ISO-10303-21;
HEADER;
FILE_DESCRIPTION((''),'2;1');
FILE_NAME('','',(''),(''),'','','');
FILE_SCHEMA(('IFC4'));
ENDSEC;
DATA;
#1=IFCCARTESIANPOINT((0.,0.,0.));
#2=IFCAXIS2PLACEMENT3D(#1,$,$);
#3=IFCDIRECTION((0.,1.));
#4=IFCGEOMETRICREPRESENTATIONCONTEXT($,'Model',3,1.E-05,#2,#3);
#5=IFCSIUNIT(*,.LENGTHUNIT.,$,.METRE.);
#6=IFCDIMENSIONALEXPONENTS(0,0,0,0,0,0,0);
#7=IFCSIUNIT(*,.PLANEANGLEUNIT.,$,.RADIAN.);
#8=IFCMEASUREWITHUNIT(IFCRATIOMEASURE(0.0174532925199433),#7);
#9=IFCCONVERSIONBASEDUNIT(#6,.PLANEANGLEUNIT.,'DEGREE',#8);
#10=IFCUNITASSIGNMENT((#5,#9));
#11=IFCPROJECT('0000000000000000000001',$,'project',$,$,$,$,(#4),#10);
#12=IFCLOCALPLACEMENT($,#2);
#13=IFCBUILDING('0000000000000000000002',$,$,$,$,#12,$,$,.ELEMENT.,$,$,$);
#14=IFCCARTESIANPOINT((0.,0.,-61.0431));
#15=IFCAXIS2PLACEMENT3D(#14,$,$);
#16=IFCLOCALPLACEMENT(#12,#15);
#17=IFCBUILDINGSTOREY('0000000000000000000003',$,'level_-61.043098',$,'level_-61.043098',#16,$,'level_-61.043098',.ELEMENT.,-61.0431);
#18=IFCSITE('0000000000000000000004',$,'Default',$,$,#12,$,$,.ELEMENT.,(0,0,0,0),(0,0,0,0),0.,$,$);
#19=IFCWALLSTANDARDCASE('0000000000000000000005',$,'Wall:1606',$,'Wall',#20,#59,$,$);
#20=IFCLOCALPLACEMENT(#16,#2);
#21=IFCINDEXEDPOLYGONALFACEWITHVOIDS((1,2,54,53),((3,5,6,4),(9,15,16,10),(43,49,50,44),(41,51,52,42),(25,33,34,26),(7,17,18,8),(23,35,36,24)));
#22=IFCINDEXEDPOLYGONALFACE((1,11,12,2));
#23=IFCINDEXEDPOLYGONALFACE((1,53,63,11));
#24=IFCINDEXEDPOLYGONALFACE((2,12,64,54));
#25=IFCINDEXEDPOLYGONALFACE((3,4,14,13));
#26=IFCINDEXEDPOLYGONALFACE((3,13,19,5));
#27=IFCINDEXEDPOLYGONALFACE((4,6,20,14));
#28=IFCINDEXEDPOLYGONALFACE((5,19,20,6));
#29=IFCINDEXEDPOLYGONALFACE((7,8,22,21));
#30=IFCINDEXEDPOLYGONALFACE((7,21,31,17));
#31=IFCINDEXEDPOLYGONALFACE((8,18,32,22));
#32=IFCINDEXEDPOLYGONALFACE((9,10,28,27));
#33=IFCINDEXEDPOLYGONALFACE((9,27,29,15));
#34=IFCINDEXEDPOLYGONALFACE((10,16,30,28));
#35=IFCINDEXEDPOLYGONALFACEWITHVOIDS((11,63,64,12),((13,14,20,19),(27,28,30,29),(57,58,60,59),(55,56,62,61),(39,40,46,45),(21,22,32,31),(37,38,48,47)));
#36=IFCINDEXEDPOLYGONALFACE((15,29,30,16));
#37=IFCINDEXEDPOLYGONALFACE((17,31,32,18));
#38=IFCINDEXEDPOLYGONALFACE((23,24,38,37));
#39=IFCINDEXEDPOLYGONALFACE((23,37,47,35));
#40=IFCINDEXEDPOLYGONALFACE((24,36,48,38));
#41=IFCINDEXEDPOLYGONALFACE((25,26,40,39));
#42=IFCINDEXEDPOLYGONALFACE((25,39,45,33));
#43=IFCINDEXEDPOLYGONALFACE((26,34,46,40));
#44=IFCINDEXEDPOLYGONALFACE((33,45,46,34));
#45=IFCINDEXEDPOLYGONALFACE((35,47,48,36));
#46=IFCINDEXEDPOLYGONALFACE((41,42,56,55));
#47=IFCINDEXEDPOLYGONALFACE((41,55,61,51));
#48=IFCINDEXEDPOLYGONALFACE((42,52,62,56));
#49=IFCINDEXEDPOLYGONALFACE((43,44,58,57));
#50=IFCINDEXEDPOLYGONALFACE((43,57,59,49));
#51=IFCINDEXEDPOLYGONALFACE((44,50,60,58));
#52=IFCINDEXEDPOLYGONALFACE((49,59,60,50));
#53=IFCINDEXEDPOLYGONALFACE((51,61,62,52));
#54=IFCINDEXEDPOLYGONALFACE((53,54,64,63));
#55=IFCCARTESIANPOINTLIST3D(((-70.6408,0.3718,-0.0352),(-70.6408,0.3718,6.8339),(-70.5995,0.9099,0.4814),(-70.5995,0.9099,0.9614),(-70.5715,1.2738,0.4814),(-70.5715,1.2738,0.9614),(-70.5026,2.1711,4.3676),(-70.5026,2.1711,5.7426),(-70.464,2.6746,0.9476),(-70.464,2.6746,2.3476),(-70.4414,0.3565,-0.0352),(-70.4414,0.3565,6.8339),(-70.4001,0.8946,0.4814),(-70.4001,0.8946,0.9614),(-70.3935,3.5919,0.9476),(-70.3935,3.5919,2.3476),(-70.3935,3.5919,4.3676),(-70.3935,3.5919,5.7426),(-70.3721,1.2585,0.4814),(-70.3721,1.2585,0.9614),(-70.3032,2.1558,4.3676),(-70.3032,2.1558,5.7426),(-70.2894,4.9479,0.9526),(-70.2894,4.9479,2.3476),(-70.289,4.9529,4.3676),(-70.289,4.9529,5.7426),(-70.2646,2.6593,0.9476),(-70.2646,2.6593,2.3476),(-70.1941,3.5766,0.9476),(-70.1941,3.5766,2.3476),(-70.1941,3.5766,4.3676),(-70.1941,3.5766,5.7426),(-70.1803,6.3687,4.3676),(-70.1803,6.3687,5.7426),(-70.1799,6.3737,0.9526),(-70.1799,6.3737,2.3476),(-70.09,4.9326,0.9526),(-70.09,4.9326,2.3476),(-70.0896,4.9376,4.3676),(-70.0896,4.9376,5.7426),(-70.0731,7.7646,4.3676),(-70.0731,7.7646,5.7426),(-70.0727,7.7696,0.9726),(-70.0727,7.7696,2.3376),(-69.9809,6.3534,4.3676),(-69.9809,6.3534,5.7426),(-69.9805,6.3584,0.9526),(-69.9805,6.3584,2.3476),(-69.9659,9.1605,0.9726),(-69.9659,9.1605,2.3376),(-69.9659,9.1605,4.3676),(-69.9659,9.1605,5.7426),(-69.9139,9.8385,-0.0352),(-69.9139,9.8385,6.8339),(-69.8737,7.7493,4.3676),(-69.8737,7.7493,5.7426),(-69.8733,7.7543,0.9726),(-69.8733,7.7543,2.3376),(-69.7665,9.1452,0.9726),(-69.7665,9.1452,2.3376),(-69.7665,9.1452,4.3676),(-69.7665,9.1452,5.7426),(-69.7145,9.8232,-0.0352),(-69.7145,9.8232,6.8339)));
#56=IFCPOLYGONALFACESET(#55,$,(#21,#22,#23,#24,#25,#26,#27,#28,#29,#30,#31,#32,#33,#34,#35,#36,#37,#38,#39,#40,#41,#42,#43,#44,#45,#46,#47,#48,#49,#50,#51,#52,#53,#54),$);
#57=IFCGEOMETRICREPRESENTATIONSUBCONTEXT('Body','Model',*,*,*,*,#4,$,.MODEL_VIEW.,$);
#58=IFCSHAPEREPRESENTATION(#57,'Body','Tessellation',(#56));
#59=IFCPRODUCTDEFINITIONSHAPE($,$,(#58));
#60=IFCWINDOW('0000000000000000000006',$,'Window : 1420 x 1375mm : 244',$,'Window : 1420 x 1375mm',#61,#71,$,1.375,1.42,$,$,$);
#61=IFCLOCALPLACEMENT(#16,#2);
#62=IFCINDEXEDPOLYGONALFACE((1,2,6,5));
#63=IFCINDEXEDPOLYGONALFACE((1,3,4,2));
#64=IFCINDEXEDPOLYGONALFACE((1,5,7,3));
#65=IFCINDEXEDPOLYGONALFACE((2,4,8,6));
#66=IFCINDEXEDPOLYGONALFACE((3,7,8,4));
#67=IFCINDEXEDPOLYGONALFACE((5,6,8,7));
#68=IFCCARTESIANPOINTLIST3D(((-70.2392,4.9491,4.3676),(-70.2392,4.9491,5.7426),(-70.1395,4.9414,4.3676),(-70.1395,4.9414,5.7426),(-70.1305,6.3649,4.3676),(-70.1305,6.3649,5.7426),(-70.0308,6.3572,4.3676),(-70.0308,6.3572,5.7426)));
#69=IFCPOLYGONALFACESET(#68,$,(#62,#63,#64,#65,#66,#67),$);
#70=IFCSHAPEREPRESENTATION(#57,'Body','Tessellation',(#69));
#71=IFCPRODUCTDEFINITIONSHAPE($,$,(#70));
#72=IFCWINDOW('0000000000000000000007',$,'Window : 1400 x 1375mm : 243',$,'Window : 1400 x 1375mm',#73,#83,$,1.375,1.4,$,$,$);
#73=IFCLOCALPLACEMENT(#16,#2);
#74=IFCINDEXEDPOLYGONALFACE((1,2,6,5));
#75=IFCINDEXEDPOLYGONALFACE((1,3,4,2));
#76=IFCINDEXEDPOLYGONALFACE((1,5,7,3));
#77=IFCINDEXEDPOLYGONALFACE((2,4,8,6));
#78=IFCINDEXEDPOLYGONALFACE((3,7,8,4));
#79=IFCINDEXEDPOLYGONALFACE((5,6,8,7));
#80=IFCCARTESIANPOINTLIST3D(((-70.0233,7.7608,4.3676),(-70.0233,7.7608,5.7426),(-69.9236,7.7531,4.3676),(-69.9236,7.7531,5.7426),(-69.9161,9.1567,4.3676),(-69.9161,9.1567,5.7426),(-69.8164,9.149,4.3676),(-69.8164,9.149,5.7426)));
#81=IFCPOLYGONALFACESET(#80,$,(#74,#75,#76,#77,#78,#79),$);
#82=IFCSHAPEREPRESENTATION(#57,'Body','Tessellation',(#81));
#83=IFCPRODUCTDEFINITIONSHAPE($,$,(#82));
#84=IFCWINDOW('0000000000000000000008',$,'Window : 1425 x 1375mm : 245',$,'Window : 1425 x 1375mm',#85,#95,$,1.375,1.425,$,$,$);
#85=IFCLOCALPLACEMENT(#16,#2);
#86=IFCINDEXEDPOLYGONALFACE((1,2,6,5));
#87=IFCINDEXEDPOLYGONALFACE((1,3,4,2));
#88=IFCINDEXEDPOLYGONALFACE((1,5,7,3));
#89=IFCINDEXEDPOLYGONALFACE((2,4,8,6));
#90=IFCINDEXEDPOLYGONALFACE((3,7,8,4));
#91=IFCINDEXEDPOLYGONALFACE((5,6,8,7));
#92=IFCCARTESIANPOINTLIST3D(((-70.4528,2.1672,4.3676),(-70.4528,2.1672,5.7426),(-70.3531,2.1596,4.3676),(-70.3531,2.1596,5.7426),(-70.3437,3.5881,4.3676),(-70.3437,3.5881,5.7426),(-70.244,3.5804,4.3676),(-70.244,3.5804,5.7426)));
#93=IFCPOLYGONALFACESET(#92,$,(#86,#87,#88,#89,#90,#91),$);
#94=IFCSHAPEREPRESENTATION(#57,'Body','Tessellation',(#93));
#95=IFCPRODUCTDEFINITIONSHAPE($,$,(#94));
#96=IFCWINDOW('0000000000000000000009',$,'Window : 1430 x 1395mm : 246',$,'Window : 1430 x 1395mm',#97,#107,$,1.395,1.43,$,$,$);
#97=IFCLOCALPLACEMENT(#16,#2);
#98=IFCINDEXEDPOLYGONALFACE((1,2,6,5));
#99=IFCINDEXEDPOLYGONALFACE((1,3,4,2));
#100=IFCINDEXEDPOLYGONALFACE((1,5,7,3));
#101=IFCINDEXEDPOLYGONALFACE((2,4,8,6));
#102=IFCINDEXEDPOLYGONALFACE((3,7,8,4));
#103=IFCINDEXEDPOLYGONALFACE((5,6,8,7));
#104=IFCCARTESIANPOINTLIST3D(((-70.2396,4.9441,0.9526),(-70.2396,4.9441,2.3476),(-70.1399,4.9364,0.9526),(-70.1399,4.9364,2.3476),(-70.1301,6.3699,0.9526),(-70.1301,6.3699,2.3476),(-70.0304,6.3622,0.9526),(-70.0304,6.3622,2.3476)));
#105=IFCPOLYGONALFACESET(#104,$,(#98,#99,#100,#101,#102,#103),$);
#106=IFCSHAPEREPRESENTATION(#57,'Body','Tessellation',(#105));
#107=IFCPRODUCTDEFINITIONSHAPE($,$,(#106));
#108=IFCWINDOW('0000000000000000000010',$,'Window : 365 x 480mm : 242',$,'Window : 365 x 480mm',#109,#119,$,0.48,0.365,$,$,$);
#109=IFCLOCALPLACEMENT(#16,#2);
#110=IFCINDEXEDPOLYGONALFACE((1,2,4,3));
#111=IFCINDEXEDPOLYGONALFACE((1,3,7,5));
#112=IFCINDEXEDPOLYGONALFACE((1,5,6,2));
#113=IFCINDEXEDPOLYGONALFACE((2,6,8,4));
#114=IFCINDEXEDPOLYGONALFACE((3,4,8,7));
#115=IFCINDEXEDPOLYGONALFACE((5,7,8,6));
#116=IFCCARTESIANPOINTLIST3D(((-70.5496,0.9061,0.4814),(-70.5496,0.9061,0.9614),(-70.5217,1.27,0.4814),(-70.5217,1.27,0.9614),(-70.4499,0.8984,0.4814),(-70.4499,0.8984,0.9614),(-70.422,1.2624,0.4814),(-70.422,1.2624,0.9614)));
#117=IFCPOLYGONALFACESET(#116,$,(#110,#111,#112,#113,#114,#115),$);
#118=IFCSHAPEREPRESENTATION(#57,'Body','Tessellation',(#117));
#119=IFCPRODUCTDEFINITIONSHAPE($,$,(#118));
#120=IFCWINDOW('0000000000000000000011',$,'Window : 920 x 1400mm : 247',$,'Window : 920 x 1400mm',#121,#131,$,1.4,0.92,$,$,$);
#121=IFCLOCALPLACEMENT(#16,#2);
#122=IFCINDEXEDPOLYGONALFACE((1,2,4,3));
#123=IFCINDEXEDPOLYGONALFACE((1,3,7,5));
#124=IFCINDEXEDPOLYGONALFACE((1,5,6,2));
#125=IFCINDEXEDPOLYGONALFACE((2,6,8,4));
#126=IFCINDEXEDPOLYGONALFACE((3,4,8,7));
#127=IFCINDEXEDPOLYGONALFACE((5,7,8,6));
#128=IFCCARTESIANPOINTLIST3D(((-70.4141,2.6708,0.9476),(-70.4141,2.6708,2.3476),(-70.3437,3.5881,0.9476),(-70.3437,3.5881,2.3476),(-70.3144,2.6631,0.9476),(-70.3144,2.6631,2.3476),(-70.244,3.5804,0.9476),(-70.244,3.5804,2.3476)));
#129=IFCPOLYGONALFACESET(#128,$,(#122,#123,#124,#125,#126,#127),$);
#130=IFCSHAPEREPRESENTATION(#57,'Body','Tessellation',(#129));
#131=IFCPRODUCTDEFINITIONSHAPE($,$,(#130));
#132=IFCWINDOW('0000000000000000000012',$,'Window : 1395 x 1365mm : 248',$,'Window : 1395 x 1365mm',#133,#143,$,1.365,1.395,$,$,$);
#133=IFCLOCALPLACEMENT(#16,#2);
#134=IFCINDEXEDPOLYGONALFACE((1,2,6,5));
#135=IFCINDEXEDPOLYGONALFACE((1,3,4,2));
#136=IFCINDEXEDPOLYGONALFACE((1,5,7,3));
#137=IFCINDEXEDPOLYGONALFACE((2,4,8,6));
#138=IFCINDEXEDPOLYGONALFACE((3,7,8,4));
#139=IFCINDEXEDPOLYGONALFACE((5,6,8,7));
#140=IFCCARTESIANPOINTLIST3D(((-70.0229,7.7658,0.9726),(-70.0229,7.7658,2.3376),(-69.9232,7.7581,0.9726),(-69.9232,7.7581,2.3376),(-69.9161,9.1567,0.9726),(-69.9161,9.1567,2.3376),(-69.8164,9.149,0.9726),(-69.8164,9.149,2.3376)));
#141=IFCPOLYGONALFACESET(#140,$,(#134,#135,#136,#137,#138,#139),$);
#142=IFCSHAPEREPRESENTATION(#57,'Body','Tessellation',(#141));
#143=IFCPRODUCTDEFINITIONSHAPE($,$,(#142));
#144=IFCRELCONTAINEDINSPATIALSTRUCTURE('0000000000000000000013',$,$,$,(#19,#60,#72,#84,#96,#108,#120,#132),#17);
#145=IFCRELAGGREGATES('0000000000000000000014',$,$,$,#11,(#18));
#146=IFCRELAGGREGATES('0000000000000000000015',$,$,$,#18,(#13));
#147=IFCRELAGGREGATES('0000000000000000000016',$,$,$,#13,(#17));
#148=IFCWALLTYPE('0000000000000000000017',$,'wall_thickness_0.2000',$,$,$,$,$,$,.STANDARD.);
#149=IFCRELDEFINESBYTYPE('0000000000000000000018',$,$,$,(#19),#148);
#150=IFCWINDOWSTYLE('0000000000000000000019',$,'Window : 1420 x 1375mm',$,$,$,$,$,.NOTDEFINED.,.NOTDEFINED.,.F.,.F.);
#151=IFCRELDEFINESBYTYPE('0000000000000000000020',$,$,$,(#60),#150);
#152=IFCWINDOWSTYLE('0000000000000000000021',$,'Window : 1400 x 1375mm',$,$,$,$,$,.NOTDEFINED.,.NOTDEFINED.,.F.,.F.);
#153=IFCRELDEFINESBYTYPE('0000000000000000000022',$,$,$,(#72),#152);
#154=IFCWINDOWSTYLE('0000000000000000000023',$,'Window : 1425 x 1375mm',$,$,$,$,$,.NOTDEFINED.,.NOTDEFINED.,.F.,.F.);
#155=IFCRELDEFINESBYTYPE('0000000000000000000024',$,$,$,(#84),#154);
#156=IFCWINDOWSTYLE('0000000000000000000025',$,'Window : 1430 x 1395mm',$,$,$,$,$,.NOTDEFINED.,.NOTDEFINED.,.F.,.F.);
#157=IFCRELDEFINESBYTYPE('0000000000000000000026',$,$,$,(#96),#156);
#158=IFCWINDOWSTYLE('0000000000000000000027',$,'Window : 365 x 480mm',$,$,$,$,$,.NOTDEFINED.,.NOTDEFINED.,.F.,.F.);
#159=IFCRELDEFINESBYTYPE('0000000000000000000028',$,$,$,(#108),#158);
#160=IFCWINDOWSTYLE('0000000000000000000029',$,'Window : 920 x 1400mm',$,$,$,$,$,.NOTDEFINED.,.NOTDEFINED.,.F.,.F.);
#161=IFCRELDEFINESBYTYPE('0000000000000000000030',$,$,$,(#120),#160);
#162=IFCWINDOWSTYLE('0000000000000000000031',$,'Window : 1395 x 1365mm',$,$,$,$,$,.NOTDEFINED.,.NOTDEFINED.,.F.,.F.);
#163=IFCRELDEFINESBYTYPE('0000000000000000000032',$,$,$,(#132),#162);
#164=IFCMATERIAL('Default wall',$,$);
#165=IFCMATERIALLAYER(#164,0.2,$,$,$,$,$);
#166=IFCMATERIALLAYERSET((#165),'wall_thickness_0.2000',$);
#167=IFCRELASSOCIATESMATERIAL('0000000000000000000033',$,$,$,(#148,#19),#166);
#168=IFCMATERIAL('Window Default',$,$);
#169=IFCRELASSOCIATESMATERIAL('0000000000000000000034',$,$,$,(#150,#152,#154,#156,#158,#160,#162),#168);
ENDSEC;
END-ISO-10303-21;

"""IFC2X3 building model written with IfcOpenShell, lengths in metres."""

from ifc_helpers import new_model, entity, si_unit, converted_unit, direction, frame, frame_2d, origin, origin_2d_with_axis, place, context, subcontext, project, spatial, polyline, rectangle, outline, extrude, source, transform, mapped, material, layer, layer_set, layer_usage, type_object, type_shapes, element, fill, save


model = new_model("IFC2X3")

# Units and contexts
model_context = context("Model", 3, precision=1e-05, world=origin(), true_north=direction((0.0, 1.0)))
body_context = subcontext(model_context, "Body", "Model", "MODEL_VIEW")
ifc_project = project(units=[si_unit("LENGTHUNIT", "METRE"), converted_unit("PLANEANGLEUNIT", "DEGREE", entity("IfcRatioMeasure", 0.0174532925199433), si_unit("PLANEANGLEUNIT", "RADIAN"), dimensions=[0, 0, 0, 0, 0, 0, 0])], contexts=[model_context])

# Site, building, storey
placement_1 = place(None, origin())
site = spatial("IfcSite", under=ifc_project, at=placement_1, Name="Default", CompositionType="ELEMENT", RefLatitude=(0, 0, 0, 0), RefLongitude=(0, 0, 0, 0), RefElevation=0.0)
building = spatial("IfcBuilding", under=site, at=placement_1, CompositionType="ELEMENT")
storey_placement = place(placement_1, frame((0.0, 0.0, -61.0431)))
storey = spatial("IfcBuildingStorey", under=building, at=storey_placement, Name="level_-61.043098", ObjectType="level_-61.043098", LongName="level_-61.043098", CompositionType="ELEMENT", Elevation=-61.0431)

# Shared definitions
ifc_material_1 = material(Name="Default wall")
ifc_layer = layer(ifc_material_1, 0.2)
ifc_layer_set = layer_set([ifc_layer], Name="wall_thickness_0.2000")
ifc_layer_usage = layer_usage(ifc_layer_set, "AXIS2", "POSITIVE", -0.1)
wall_type = type_object("IfcWallType", Name="wall_thickness_0.2000", PredefinedType="STANDARD", material=ifc_layer_set)

# Wall, openings, windows
placement_2 = place(placement_1, frame((0.0, 0.0, -61.0783)))
wall_1_placement = place(placement_2, frame((-69.8142, 9.8308, 0.0), z_axis=(0.0, 0.0, 1.0), x_axis=(-0.076563, -0.997065, 0.0)))
wall_1 = element("IfcWallStandardCase", 1, at=wall_1_placement, inside=storey, type_object=wall_type, material=ifc_layer_usage, Name="Wall:1606", ObjectType="Wall", context=body_context, shape_type="SweptSolid", body=[
    extrude(outline(polyline([(9.4946, -0.1), (9.4946, 0.1), (0.0, 0.1), (0.0, -0.1), (9.4946, -0.1)])), origin(), (0.0, 0.0, 1.0), 6.8691),
])
opening_1_placement = place(wall_1_placement, frame((8.5899, -0.1, 0.5166)))
opening_1 = element("IfcOpeningElement", 2, at=opening_1_placement, cuts=wall_1, ObjectType="Opening", context=body_context, shape_type="SweptSolid", body=[
    extrude(rectangle(XDim=0.365, YDim=0.48, at=frame_2d((0.24, 0.1825), x_axis=(0.0, 1.0))), frame((0.0, 0.0, 0.0), z_axis=(0.0, 1.0, 0.0), x_axis=(0.0, 0.0, 1.0)), (0.0, 0.0, 1.0), 0.2),
])
opening_2_placement = place(wall_1_placement, frame((0.68, -0.1, 4.4028)))
opening_2 = element("IfcOpeningElement", 3, at=opening_2_placement, cuts=wall_1, ObjectType="Opening", context=body_context, shape_type="SweptSolid", body=[
    extrude(rectangle(XDim=1.4, YDim=1.375, at=frame_2d((0.6875, 0.7), x_axis=(0.0, 1.0))), frame((0.0, 0.0, 0.0), z_axis=(0.0, 1.0, 0.0), x_axis=(0.0, 0.0, 1.0)), (0.0, 0.0, 1.0), 0.2),
])
opening_3_placement = place(wall_1_placement, frame((3.48, -0.1, 4.4028)))
opening_3 = element("IfcOpeningElement", 4, at=opening_3_placement, cuts=wall_1, ObjectType="Opening", context=body_context, shape_type="SweptSolid", body=[
    extrude(rectangle(XDim=1.42, YDim=1.375, at=frame_2d((0.6875, 0.71), x_axis=(0.0, 1.0))), frame((0.0, 0.0, 0.0), z_axis=(0.0, 1.0, 0.0), x_axis=(0.0, 0.0, 1.0)), (0.0, 0.0, 1.0), 0.2),
])
opening_4_placement = place(wall_1_placement, frame((6.265, -0.1, 4.4028)))
opening_4 = element("IfcOpeningElement", 5, at=opening_4_placement, cuts=wall_1, ObjectType="Opening", context=body_context, shape_type="SweptSolid", body=[
    extrude(rectangle(XDim=1.425, YDim=1.375, at=frame_2d((0.6875, 0.7125), x_axis=(0.0, 1.0))), frame((0.0, 0.0, 0.0), z_axis=(0.0, 1.0, 0.0), x_axis=(0.0, 0.0, 1.0)), (0.0, 0.0, 1.0), 0.2),
])
opening_5_placement = place(wall_1_placement, frame((3.475, -0.1, 0.9878)))
opening_5 = element("IfcOpeningElement", 6, at=opening_5_placement, cuts=wall_1, ObjectType="Opening", context=body_context, shape_type="SweptSolid", body=[
    extrude(rectangle(XDim=1.43, YDim=1.395, at=frame_2d((0.6975, 0.715), x_axis=(0.0, 1.0))), frame((0.0, 0.0, 0.0), z_axis=(0.0, 1.0, 0.0), x_axis=(0.0, 0.0, 1.0)), (0.0, 0.0, 1.0), 0.2),
])
opening_6_placement = place(wall_1_placement, frame((6.265, -0.1, 0.9828)))
opening_6 = element("IfcOpeningElement", 7, at=opening_6_placement, cuts=wall_1, ObjectType="Opening", context=body_context, shape_type="SweptSolid", body=[
    extrude(rectangle(XDim=0.92, YDim=1.4, at=frame_2d((0.7, 0.46), x_axis=(0.0, 1.0))), frame((0.0, 0.0, 0.0), z_axis=(0.0, 1.0, 0.0), x_axis=(0.0, 0.0, 1.0)), (0.0, 0.0, 1.0), 0.2),
])
opening_7_placement = place(wall_1_placement, frame((0.68, -0.1, 1.0078)))
opening_7 = element("IfcOpeningElement", 8, at=opening_7_placement, cuts=wall_1, ObjectType="Opening", context=body_context, shape_type="SweptSolid", body=[
    extrude(rectangle(XDim=1.395, YDim=1.365, at=frame_2d((0.6825, 0.6975), x_axis=(0.0, 1.0))), frame((0.0, 0.0, 0.0), z_axis=(0.0, 1.0, 0.0), x_axis=(0.0, 0.0, 1.0)), (0.0, 0.0, 1.0), 0.2),
])
ifc_material_2 = material(Name="Window Default")
window_style_1 = type_object("IfcWindowStyle", Name="Window : 1420 x 1375mm", ConstructionType="NOTDEFINED", OperationType="NOTDEFINED", ParameterTakesPrecedence=False, Sizeable=False, material=ifc_material_2)
shared_shape_1 = source(origin(), body_context, "Body", "SweptSolid", [
    extrude(rectangle(XDim=0.1, YDim=1.42, at=origin_2d_with_axis()), frame((0.71, 0.1, 0.0), z_axis=(0.0, 0.0, 1.0), x_axis=(0.0, 1.0, 0.0)), (0.0, 0.0, 1.0), 1.375),
])
type_shapes(window_style_1, [shared_shape_1])
window_1_placement = place(opening_3_placement, origin())
window_1 = element("IfcWindow", 9, at=window_1_placement, inside=storey, type_object=window_style_1, Name="Window : 1420 x 1375mm : 244", ObjectType="Window : 1420 x 1375mm", OverallHeight=1.375, OverallWidth=1.42, context=body_context, shape_type="MappedRepresentation", body=[
    mapped(shared_shape_1, transform((0.0, 0.0, 0.0), scale=1.0)),
])
fill(opening_3, window_1)
window_style_2 = type_object("IfcWindowStyle", Name="Window : 1400 x 1375mm", ConstructionType="NOTDEFINED", OperationType="NOTDEFINED", ParameterTakesPrecedence=False, Sizeable=False, material=ifc_material_2)
shared_shape_2 = source(origin(), body_context, "Body", "SweptSolid", [
    extrude(rectangle(XDim=0.1, YDim=1.4, at=origin_2d_with_axis()), frame((0.7, 0.1, 0.0), z_axis=(0.0, 0.0, 1.0), x_axis=(0.0, 1.0, 0.0)), (0.0, 0.0, 1.0), 1.375),
])
type_shapes(window_style_2, [shared_shape_2])
window_2_placement = place(opening_2_placement, origin())
window_2 = element("IfcWindow", 10, at=window_2_placement, inside=storey, type_object=window_style_2, Name="Window : 1400 x 1375mm : 243", ObjectType="Window : 1400 x 1375mm", OverallHeight=1.375, OverallWidth=1.4, context=body_context, shape_type="MappedRepresentation", body=[
    mapped(shared_shape_2, transform((0.0, 0.0, 0.0), scale=1.0)),
])
fill(opening_2, window_2)
window_style_3 = type_object("IfcWindowStyle", Name="Window : 1425 x 1375mm", ConstructionType="NOTDEFINED", OperationType="NOTDEFINED", ParameterTakesPrecedence=False, Sizeable=False, material=ifc_material_2)
shared_shape_3 = source(origin(), body_context, "Body", "SweptSolid", [
    extrude(rectangle(XDim=0.1, YDim=1.425, at=origin_2d_with_axis()), frame((0.7125, 0.1, 0.0), z_axis=(0.0, 0.0, 1.0), x_axis=(0.0, 1.0, 0.0)), (0.0, 0.0, 1.0), 1.375),
])
type_shapes(window_style_3, [shared_shape_3])
window_3_placement = place(opening_4_placement, origin())
window_3 = element("IfcWindow", 11, at=window_3_placement, inside=storey, type_object=window_style_3, Name="Window : 1425 x 1375mm : 245", ObjectType="Window : 1425 x 1375mm", OverallHeight=1.375, OverallWidth=1.425, context=body_context, shape_type="MappedRepresentation", body=[
    mapped(shared_shape_3, transform((0.0, 0.0, 0.0), scale=1.0)),
])
fill(opening_4, window_3)
window_style_4 = type_object("IfcWindowStyle", Name="Window : 1430 x 1395mm", ConstructionType="NOTDEFINED", OperationType="NOTDEFINED", ParameterTakesPrecedence=False, Sizeable=False, material=ifc_material_2)
shared_shape_4 = source(origin(), body_context, "Body", "SweptSolid", [
    extrude(rectangle(XDim=0.1, YDim=1.43, at=origin_2d_with_axis()), frame((0.715, 0.1, 0.0), z_axis=(0.0, 0.0, 1.0), x_axis=(0.0, 1.0, 0.0)), (0.0, 0.0, 1.0), 1.395),
])
type_shapes(window_style_4, [shared_shape_4])
window_4_placement = place(opening_5_placement, origin())
window_4 = element("IfcWindow", 12, at=window_4_placement, inside=storey, type_object=window_style_4, Name="Window : 1430 x 1395mm : 246", ObjectType="Window : 1430 x 1395mm", OverallHeight=1.395, OverallWidth=1.43, context=body_context, shape_type="MappedRepresentation", body=[
    mapped(shared_shape_4, transform((0.0, 0.0, 0.0), scale=1.0)),
])
fill(opening_5, window_4)
window_style_5 = type_object("IfcWindowStyle", Name="Window : 365 x 480mm", ConstructionType="NOTDEFINED", OperationType="NOTDEFINED", ParameterTakesPrecedence=False, Sizeable=False, material=ifc_material_2)
shared_shape_5 = source(origin(), body_context, "Body", "SweptSolid", [
    extrude(rectangle(XDim=0.1, YDim=0.365, at=origin_2d_with_axis()), frame((0.1825, 0.1, 0.0), z_axis=(0.0, 0.0, 1.0), x_axis=(0.0, 1.0, 0.0)), (0.0, 0.0, 1.0), 0.48),
])
type_shapes(window_style_5, [shared_shape_5])
window_5_placement = place(opening_1_placement, origin())
window_5 = element("IfcWindow", 13, at=window_5_placement, inside=storey, type_object=window_style_5, Name="Window : 365 x 480mm : 242", ObjectType="Window : 365 x 480mm", OverallHeight=0.48, OverallWidth=0.365, context=body_context, shape_type="MappedRepresentation", body=[
    mapped(shared_shape_5, transform((0.0, 0.0, 0.0), scale=1.0)),
])
fill(opening_1, window_5)
window_style_6 = type_object("IfcWindowStyle", Name="Window : 920 x 1400mm", ConstructionType="NOTDEFINED", OperationType="NOTDEFINED", ParameterTakesPrecedence=False, Sizeable=False, material=ifc_material_2)
shared_shape_6 = source(origin(), body_context, "Body", "SweptSolid", [
    extrude(rectangle(XDim=0.1, YDim=0.92, at=origin_2d_with_axis()), frame((0.46, 0.1, 0.0), z_axis=(0.0, 0.0, 1.0), x_axis=(0.0, 1.0, 0.0)), (0.0, 0.0, 1.0), 1.4),
])
type_shapes(window_style_6, [shared_shape_6])
window_6_placement = place(opening_6_placement, origin())
window_6 = element("IfcWindow", 14, at=window_6_placement, inside=storey, type_object=window_style_6, Name="Window : 920 x 1400mm : 247", ObjectType="Window : 920 x 1400mm", OverallHeight=1.4, OverallWidth=0.92, context=body_context, shape_type="MappedRepresentation", body=[
    mapped(shared_shape_6, transform((0.0, 0.0, 0.0), scale=1.0)),
])
fill(opening_6, window_6)
window_style_7 = type_object("IfcWindowStyle", Name="Window : 1395 x 1365mm", ConstructionType="NOTDEFINED", OperationType="NOTDEFINED", ParameterTakesPrecedence=False, Sizeable=False, material=ifc_material_2)
shared_shape_7 = source(origin(), body_context, "Body", "SweptSolid", [
    extrude(rectangle(XDim=0.1, YDim=1.395, at=origin_2d_with_axis()), frame((0.6975, 0.1, 0.0), z_axis=(0.0, 0.0, 1.0), x_axis=(0.0, 1.0, 0.0)), (0.0, 0.0, 1.0), 1.365),
])
type_shapes(window_style_7, [shared_shape_7])
window_7_placement = place(opening_7_placement, origin())
window_7 = element("IfcWindow", 15, at=window_7_placement, inside=storey, type_object=window_style_7, Name="Window : 1395 x 1365mm : 248", ObjectType="Window : 1395 x 1365mm", OverallHeight=1.365, OverallWidth=1.395, context=body_context, shape_type="MappedRepresentation", body=[
    mapped(shared_shape_7, transform((0.0, 0.0, 0.0), scale=1.0)),
])
fill(opening_7, window_7)

save(model, "model.ifc")
